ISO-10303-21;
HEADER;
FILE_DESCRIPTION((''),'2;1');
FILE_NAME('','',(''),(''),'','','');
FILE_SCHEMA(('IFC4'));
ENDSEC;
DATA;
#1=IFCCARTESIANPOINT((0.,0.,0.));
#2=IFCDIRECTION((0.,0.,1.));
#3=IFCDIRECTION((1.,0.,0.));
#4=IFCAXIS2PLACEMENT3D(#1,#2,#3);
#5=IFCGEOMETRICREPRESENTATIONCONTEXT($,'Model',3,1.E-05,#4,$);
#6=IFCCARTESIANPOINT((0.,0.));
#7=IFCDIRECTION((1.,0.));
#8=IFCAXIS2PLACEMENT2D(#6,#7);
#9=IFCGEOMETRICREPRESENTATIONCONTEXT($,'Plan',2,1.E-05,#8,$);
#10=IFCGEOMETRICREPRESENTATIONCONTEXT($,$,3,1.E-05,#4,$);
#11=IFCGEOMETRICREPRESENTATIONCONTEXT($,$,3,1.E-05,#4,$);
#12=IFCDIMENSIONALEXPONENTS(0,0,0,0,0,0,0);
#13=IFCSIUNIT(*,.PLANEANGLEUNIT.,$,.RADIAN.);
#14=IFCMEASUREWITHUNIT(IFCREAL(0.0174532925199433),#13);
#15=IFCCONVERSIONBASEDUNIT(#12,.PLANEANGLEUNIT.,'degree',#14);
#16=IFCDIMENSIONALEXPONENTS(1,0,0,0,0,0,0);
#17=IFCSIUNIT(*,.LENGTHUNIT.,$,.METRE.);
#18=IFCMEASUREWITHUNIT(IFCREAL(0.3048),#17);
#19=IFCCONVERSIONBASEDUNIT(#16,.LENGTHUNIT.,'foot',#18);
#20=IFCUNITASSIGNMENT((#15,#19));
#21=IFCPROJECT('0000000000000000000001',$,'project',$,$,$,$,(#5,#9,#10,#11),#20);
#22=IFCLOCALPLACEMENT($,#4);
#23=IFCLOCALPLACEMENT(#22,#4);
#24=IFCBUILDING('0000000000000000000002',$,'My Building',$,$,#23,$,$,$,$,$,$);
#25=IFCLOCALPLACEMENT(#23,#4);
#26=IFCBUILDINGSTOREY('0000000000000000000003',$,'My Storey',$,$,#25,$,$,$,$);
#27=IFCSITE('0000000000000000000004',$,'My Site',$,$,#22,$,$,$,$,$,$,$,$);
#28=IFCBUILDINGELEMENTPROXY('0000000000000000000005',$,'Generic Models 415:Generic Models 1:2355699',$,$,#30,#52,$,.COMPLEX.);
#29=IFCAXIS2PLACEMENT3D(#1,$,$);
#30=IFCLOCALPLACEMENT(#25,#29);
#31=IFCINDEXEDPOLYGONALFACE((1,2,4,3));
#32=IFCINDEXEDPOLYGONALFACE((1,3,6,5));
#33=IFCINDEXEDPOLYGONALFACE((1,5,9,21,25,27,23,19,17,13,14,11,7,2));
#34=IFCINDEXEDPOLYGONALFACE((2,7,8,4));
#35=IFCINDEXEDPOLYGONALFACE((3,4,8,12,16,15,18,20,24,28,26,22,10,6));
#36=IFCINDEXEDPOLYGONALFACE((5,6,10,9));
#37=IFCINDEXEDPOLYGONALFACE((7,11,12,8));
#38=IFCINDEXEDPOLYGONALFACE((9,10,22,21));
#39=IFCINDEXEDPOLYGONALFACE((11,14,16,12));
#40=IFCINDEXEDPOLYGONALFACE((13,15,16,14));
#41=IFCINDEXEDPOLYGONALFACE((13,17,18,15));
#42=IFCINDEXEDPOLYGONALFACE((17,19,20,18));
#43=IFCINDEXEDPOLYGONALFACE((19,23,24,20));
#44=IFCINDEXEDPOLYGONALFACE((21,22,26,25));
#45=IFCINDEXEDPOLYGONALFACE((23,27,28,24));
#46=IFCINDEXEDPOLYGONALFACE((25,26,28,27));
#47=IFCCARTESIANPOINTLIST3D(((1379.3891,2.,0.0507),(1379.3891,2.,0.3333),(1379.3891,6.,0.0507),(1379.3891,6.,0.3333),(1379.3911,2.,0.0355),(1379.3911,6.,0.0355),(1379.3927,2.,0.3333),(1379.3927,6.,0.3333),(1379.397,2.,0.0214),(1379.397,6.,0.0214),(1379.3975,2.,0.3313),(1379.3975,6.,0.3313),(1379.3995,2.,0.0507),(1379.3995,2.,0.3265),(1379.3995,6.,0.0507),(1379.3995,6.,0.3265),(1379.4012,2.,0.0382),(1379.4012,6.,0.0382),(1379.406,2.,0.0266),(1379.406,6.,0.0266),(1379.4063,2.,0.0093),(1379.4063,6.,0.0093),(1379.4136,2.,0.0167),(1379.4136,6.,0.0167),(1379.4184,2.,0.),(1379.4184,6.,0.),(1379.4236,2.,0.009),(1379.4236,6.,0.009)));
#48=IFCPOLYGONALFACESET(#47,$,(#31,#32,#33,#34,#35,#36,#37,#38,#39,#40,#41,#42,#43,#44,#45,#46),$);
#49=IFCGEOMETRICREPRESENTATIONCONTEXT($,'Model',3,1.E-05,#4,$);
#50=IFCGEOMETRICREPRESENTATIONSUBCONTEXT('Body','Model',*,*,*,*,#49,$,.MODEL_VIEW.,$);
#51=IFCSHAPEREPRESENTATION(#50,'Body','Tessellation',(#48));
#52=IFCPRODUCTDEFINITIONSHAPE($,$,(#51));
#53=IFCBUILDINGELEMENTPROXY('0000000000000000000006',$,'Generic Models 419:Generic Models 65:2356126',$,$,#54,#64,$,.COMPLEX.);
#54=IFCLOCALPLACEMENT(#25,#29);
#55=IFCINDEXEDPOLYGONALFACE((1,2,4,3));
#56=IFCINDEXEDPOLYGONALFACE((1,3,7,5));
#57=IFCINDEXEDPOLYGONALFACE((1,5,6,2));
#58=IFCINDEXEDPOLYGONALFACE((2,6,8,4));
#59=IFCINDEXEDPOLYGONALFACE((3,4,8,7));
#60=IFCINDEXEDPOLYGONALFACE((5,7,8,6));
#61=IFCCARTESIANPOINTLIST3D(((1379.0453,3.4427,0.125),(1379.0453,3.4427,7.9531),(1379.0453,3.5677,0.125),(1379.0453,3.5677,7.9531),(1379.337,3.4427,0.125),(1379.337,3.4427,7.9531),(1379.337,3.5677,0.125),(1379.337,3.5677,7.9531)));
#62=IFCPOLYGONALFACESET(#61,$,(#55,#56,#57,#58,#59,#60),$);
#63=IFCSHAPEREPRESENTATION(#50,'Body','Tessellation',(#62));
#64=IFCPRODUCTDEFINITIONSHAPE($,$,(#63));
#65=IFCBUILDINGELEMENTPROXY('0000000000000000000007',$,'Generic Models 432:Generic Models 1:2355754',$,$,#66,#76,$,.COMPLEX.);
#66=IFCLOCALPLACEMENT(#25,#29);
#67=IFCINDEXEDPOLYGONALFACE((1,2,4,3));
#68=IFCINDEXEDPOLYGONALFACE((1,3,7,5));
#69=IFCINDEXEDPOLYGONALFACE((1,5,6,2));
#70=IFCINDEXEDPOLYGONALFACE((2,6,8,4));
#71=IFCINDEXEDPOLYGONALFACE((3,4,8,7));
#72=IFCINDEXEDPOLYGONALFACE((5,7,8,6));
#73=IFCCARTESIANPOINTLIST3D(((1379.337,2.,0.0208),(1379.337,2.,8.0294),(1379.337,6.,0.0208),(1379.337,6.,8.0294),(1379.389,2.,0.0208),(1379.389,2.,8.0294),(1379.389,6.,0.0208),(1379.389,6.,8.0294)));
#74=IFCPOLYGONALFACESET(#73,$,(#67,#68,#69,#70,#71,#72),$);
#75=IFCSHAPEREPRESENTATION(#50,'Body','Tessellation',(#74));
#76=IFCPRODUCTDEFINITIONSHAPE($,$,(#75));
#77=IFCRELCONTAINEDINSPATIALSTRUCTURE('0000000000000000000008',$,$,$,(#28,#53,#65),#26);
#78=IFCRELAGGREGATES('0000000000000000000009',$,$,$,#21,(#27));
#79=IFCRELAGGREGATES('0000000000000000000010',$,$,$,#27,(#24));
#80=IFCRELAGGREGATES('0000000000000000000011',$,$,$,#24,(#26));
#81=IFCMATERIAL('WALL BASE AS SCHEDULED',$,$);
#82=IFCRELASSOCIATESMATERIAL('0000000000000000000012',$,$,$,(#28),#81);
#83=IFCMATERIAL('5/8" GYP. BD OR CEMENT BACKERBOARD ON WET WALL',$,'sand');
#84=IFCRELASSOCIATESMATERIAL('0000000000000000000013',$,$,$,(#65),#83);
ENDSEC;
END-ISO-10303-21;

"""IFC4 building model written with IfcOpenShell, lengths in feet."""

from ifc_helpers import new_model, entity, si_unit, converted_unit, frame, origin_with_axes, origin_2d_with_axis, place, context, subcontext, project, spatial, polyline, outline, extrude, material, element, save


model = new_model("IFC4")

# Units and contexts
model_context_1 = context("Model", 3, precision=1e-05, world=origin_with_axes())
plan_context = context("Plan", 2, precision=1e-05, world=origin_2d_with_axis())
model_context_2 = context("Model", 3, precision=1e-05, world=origin_with_axes())
context_of_model_1 = context(None, 3, precision=1e-05, world=origin_with_axes())
context_of_model_2 = context(None, 3, precision=1e-05, world=origin_with_axes())
body_context = subcontext(model_context_2, "Body", "Model", "MODEL_VIEW")
ifc_project = project(units=[converted_unit("PLANEANGLEUNIT", "degree", entity("IfcReal", 0.0174532925199433), si_unit("PLANEANGLEUNIT", "RADIAN"), dimensions=[0, 0, 0, 0, 0, 0, 0]), converted_unit("LENGTHUNIT", "foot", entity("IfcReal", 0.3048), si_unit("LENGTHUNIT", "METRE"), dimensions=[1, 0, 0, 0, 0, 0, 0])], contexts=[model_context_1, plan_context, context_of_model_1, context_of_model_2])

# Site, building, storey
site_placement = place(None, origin_with_axes())
site = spatial("IfcSite", under=ifc_project, at=site_placement, Name="My Site")
building_placement = place(site_placement, origin_with_axes())
building = spatial("IfcBuilding", under=site, at=building_placement, Name="My Building")
storey_placement = place(building_placement, origin_with_axes())
storey = spatial("IfcBuildingStorey", under=building, at=storey_placement, Name="My Storey")

# Building element proxies
ifc_material_1 = material(Name="5/8\" GYP. BD OR CEMENT BACKERBOARD ON WET WALL", Category="sand")
ifc_material_2 = material(Name="WALL BASE AS SCHEDULED")
proxy_1_placement = place(storey_placement, frame((1379.3891, 6.0, 0.0), z_axis=(0.0, -1.0, 0.0), x_axis=(0.0, 0.0, 1.0)))
element("IfcBuildingElementProxy", 1, at=proxy_1_placement, inside=storey, material=ifc_material_2, Name="Generic Models 415:Generic Models 1:2355699", PredefinedType="COMPLEX", context=body_context, shape_type="SweptSolid", body=[
    extrude(outline(polyline([(-0.2134, 0.0022), (0.0624, 0.0022), (0.0748, 0.0006), (0.0864, -0.0042), (0.0964, -0.0119), (0.104, -0.0218), (0.113, -0.0166), (0.1037, -0.0045), (0.0916, 0.0048), (0.0775, 0.0106), (0.0624, 0.0126), (-0.2203, 0.0126), (-0.2203, 0.0091), (-0.2183, 0.0042), (-0.2134, 0.0022)])), frame((0.113, -0.0126, 0.0), z_axis=(0.0, 0.0, -1.0), x_axis=(-1.0, 0.0, 0.0)), (0.0, 0.0, -1.0), 4.0),
])
proxy_2_placement = place(storey_placement, frame((1379.0453, 3.4427, 0.125), z_axis=(0.0, 0.0, 1.0), x_axis=(1.0, 0.0, 0.0)))
element("IfcBuildingElementProxy", 2, at=proxy_2_placement, inside=storey, Name="Generic Models 419:Generic Models 65:2356126", PredefinedType="COMPLEX", context=body_context, shape_type="SweptSolid", body=[
    extrude(outline(polyline([(-0.1458, -0.0625), (0.1458, -0.0625), (0.1458, 0.0625), (-0.1458, 0.0625), (-0.1458, -0.0625)])), frame((0.1458, 0.0625, 0.0), z_axis=(0.0, 0.0, -1.0), x_axis=(-1.0, 0.0, 0.0)), (0.0, 0.0, -1.0), 7.8281),
])
proxy_3_placement = place(storey_placement, frame((1379.337, 6.0, 0.0208), z_axis=(0.0, -1.0, 0.0), x_axis=(0.0, 0.0, 1.0)))
element("IfcBuildingElementProxy", 3, at=proxy_3_placement, inside=storey, material=ifc_material_1, Name="Generic Models 432:Generic Models 1:2355754", PredefinedType="COMPLEX", context=body_context, shape_type="SweptSolid", body=[
    extrude(outline(polyline([(-4.0043, -0.026), (4.0043, -0.026), (4.0043, 0.026), (-4.0043, 0.026), (-4.0043, -0.026)])), frame((4.0043, -0.026, 0.0), z_axis=(0.0, 0.0, -1.0), x_axis=(1.0, 0.0, 0.0)), (0.0, 0.0, -1.0), 4.0),
])

save(model, "model.ifc")
